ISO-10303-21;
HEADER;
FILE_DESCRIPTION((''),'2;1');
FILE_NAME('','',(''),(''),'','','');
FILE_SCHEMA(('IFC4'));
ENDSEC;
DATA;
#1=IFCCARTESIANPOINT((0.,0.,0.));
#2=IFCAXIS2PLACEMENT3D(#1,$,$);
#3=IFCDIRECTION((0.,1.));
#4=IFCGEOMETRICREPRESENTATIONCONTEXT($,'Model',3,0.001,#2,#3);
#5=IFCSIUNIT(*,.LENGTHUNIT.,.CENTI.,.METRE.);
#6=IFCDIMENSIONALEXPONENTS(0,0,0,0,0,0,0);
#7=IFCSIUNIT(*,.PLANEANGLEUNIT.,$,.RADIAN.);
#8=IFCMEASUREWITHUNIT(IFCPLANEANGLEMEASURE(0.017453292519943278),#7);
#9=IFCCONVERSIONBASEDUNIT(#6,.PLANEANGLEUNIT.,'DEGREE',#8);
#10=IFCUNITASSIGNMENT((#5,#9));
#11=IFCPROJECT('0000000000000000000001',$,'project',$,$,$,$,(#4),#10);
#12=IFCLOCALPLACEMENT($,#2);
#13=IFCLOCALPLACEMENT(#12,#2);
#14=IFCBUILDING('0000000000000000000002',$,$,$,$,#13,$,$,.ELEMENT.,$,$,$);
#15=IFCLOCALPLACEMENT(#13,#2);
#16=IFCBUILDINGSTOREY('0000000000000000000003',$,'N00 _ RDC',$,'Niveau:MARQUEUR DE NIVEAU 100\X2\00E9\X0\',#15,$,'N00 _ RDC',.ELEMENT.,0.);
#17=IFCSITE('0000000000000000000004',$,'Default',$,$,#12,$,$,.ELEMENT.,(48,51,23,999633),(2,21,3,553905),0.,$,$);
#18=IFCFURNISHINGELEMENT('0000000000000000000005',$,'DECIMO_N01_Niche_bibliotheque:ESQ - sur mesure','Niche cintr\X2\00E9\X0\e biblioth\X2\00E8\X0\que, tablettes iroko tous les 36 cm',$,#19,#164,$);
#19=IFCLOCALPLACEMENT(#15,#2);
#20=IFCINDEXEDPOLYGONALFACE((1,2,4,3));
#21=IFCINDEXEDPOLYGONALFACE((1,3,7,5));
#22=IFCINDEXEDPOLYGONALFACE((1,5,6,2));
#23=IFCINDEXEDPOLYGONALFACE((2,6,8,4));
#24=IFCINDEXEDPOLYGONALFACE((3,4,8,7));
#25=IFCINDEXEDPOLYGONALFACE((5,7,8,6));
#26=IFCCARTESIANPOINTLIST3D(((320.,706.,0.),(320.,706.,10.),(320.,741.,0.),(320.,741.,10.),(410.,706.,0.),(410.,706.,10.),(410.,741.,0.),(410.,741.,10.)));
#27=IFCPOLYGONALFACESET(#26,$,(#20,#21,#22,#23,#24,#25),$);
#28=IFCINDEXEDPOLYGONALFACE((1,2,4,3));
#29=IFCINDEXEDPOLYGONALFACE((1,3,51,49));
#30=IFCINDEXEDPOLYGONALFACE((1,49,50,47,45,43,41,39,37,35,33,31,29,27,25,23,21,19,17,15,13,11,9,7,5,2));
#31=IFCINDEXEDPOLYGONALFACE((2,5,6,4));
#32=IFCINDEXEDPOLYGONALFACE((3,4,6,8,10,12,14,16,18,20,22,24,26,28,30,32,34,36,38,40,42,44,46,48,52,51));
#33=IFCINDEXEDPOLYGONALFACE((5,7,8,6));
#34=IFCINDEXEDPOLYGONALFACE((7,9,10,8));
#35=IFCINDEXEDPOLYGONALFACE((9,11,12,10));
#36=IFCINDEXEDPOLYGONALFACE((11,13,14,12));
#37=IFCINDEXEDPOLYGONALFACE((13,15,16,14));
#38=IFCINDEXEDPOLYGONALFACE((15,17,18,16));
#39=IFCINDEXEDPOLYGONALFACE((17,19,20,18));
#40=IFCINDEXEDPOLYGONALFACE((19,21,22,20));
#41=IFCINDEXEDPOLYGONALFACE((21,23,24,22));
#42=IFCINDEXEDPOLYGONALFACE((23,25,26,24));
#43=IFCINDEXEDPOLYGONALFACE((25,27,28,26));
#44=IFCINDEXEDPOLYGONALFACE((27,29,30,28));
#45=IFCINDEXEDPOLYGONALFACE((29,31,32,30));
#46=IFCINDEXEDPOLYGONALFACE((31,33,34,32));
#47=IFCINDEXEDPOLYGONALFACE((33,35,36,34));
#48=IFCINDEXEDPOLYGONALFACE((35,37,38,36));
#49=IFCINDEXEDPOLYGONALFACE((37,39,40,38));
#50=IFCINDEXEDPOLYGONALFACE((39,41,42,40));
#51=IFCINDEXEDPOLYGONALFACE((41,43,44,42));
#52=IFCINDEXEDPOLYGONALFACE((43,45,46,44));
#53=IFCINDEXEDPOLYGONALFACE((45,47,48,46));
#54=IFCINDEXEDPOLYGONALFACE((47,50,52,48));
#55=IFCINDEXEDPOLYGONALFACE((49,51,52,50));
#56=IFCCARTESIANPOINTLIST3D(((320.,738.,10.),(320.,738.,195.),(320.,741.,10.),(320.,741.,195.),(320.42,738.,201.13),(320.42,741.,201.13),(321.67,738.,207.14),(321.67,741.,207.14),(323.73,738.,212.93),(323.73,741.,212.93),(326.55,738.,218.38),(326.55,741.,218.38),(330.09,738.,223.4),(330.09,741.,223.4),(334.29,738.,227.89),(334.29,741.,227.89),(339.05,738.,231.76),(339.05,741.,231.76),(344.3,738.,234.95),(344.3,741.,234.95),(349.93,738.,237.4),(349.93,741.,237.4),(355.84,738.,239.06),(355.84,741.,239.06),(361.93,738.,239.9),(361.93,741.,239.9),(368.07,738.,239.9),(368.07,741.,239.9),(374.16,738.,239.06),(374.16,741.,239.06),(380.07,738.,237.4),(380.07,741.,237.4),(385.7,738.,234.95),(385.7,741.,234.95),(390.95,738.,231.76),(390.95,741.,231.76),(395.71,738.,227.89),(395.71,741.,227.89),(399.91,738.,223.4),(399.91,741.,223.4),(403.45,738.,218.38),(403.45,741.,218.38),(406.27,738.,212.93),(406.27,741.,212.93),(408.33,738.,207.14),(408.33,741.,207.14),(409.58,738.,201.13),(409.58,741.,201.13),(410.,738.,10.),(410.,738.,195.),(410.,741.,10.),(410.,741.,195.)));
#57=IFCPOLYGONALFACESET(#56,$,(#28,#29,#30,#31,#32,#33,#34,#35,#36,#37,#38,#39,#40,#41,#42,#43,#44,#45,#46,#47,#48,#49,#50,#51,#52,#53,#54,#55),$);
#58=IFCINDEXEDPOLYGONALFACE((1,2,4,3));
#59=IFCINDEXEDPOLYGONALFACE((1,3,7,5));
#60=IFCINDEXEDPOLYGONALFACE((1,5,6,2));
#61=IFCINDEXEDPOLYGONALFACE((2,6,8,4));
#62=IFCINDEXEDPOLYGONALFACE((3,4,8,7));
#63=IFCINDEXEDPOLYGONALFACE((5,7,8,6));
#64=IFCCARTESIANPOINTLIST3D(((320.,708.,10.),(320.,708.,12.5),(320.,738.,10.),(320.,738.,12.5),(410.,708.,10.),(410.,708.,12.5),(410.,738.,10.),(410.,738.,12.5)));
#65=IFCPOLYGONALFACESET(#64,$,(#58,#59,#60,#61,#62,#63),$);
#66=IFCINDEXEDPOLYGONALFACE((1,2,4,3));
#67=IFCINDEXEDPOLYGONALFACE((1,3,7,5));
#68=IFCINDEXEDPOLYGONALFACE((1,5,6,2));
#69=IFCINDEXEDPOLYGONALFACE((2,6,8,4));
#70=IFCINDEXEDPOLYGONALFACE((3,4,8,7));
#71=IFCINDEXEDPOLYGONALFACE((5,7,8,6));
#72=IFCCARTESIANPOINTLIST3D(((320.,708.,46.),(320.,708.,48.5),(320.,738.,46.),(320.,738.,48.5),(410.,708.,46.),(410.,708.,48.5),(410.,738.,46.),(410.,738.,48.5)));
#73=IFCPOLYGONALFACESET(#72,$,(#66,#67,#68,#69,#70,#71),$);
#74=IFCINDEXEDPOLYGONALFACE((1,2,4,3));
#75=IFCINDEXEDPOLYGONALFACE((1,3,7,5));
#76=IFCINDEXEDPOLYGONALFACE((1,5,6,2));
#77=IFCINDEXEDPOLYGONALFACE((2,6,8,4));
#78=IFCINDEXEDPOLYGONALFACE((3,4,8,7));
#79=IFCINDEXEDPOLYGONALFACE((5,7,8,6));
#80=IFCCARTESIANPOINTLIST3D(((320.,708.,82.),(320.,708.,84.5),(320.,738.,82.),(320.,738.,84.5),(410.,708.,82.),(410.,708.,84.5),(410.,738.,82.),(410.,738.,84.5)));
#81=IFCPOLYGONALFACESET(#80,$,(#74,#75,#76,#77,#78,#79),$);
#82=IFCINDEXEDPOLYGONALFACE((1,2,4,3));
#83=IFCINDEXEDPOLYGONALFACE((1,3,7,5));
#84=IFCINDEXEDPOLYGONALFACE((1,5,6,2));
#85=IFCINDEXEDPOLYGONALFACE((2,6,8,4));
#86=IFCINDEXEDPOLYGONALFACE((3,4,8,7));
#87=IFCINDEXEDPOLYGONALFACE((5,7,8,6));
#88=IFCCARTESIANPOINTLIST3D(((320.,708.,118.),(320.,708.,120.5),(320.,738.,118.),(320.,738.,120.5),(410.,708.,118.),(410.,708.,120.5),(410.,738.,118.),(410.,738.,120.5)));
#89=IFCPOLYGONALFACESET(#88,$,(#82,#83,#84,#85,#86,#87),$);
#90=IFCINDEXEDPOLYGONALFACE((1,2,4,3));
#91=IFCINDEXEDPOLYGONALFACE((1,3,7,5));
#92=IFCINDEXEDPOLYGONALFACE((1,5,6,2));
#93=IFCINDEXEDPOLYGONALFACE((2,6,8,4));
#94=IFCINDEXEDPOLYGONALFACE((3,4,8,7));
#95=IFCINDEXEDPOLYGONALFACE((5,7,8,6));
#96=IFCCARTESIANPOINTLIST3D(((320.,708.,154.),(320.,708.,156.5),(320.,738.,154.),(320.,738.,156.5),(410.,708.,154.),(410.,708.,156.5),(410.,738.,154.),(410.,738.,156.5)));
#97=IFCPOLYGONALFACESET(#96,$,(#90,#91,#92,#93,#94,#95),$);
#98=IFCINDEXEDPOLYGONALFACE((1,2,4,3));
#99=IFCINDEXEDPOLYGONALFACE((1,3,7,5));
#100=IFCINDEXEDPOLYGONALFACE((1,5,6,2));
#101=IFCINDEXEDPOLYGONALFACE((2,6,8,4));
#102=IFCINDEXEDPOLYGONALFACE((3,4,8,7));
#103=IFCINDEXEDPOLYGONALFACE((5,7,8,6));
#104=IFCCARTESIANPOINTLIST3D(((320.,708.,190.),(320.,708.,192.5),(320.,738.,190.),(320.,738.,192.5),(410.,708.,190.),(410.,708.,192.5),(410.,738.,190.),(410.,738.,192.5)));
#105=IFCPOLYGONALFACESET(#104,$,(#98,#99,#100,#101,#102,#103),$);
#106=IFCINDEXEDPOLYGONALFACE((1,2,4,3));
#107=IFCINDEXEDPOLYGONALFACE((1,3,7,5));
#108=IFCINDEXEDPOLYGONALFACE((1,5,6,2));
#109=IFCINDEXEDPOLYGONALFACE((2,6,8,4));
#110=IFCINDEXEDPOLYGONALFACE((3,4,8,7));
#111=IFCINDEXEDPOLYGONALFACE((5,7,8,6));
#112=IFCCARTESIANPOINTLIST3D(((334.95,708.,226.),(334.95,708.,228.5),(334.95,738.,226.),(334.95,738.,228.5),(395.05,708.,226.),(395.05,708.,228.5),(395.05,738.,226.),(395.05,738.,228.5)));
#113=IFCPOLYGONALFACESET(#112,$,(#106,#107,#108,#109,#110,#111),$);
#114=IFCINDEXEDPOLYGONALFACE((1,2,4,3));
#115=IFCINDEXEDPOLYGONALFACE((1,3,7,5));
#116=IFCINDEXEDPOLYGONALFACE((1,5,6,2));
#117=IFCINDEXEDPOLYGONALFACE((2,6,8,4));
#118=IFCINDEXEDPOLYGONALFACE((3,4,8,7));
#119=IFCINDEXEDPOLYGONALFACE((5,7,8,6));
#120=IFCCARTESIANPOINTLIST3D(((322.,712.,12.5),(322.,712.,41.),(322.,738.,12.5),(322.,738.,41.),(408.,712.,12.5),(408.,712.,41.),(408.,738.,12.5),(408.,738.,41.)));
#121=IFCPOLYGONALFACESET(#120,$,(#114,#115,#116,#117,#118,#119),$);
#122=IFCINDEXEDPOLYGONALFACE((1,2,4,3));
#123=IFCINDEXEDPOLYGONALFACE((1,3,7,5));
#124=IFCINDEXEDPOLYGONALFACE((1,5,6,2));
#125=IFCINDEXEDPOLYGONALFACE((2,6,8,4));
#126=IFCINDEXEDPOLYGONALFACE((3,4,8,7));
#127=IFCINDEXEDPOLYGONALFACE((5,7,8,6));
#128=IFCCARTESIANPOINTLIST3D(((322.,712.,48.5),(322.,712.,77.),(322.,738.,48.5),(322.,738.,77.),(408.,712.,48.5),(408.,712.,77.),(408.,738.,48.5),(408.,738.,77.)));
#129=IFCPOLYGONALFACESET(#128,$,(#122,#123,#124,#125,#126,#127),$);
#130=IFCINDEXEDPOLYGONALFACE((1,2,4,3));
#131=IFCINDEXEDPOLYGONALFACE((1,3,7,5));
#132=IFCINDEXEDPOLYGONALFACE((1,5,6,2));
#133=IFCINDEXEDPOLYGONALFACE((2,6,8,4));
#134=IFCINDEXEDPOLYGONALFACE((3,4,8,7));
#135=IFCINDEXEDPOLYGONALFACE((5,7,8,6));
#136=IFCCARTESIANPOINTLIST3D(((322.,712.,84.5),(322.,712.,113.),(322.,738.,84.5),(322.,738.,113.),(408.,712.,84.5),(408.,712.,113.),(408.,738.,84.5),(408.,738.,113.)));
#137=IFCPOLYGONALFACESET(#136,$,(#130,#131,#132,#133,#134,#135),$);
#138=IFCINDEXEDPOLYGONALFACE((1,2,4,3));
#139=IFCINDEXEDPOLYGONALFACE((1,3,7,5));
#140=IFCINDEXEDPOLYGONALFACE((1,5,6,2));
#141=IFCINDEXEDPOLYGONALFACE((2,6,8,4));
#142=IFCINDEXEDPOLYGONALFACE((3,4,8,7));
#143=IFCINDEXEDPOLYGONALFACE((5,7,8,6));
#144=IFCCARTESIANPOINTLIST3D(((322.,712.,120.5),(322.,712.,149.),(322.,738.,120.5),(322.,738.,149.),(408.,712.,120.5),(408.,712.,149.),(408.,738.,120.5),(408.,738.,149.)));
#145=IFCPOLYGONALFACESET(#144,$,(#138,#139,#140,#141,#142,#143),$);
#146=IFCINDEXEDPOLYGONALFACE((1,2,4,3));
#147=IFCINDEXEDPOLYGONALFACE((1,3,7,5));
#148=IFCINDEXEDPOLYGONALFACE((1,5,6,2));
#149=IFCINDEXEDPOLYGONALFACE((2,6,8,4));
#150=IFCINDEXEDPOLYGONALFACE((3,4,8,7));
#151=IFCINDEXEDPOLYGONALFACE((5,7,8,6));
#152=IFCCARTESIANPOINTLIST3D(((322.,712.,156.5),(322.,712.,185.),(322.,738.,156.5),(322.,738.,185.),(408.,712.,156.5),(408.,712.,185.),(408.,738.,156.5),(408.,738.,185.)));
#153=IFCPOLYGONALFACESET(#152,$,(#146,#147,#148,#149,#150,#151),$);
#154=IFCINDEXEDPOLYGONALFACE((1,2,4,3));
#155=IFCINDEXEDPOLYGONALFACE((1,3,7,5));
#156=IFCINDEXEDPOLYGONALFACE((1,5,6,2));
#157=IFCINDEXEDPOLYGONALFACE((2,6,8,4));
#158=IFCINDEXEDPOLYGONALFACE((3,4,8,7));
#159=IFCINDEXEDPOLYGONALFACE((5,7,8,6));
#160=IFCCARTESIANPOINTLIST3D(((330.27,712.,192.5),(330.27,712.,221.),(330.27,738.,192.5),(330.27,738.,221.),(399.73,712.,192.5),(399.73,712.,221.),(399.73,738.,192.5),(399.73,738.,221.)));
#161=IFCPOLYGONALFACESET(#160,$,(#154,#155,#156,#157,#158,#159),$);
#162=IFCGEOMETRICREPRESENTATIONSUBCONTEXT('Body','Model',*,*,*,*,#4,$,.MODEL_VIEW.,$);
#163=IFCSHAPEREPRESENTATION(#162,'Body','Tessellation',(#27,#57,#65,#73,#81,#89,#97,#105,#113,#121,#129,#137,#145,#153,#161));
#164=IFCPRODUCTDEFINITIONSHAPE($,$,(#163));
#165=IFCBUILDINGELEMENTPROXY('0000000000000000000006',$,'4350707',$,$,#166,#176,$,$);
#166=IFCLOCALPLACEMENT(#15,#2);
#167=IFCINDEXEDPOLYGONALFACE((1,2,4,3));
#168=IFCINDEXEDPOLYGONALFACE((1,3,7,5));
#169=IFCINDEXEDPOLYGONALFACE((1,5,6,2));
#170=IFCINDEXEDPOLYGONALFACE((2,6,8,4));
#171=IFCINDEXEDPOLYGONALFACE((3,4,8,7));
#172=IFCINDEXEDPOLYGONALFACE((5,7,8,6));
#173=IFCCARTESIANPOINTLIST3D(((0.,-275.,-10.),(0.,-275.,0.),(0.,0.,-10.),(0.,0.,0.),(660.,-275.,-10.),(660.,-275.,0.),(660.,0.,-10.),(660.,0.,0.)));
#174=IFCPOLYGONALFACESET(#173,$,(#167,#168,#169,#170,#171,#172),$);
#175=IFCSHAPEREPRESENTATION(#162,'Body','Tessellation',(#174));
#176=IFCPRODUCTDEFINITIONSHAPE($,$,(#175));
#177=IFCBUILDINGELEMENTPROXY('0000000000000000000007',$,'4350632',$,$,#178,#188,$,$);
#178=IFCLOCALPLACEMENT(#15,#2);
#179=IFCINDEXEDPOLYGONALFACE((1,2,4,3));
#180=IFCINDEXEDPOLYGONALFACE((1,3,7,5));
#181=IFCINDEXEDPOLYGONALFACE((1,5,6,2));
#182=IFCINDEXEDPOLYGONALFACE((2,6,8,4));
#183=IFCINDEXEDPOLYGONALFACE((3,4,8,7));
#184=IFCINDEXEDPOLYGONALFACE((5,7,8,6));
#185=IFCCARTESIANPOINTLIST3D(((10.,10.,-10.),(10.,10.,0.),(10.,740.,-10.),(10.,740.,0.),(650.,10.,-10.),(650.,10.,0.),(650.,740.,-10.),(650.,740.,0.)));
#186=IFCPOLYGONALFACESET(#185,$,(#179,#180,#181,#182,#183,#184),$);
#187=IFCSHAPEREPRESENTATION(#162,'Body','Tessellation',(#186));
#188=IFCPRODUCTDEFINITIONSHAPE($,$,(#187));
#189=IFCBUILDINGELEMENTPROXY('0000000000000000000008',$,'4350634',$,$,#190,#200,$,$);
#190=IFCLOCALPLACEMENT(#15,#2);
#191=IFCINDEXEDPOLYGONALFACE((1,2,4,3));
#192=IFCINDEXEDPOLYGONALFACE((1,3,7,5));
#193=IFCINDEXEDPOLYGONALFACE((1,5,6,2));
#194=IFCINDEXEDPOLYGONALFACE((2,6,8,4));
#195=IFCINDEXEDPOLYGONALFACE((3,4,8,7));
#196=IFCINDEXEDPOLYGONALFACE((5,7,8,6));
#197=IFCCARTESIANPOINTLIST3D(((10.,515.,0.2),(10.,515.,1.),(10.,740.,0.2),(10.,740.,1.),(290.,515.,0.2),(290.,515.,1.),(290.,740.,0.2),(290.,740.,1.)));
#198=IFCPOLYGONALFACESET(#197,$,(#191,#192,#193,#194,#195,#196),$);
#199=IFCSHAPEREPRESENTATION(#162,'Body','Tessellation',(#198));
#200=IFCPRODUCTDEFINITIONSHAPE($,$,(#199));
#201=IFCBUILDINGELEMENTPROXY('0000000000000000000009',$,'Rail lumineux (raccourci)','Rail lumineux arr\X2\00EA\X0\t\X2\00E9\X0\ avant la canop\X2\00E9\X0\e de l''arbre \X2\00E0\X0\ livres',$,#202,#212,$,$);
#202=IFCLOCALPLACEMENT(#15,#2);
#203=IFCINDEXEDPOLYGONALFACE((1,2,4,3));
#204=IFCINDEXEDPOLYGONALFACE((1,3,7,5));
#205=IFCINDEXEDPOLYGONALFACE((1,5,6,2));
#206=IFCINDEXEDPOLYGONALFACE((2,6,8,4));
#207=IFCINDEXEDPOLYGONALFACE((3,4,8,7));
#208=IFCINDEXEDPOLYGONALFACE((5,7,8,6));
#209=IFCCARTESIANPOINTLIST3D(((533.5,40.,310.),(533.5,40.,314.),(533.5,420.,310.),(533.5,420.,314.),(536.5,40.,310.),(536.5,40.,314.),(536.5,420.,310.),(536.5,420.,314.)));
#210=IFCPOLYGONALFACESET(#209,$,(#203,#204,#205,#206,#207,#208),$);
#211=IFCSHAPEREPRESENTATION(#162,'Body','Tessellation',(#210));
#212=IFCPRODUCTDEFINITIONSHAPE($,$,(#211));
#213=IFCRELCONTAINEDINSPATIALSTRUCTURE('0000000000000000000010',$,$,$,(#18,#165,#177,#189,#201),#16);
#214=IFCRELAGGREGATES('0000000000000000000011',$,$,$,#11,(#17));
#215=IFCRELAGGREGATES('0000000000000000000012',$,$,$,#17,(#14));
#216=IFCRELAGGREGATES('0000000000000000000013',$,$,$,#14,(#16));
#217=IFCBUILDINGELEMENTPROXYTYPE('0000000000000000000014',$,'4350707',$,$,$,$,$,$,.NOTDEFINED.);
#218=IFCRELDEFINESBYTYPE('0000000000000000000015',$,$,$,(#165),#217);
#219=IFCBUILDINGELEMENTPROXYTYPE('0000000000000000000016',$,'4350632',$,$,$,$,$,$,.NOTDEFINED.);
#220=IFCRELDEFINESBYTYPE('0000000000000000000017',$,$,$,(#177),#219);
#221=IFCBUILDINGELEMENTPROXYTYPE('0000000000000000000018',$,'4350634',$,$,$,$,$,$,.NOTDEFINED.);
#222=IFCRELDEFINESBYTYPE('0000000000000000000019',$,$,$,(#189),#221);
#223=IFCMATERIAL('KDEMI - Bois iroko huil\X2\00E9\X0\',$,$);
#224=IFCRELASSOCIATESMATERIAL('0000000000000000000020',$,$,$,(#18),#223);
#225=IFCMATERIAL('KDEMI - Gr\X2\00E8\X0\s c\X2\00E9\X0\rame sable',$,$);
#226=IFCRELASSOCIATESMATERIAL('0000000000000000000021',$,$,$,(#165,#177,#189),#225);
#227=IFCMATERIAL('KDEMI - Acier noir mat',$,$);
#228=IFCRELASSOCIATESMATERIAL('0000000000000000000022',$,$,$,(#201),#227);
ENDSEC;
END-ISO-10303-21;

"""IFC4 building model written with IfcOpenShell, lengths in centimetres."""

from ifc_helpers import new_model, entity, si_unit, converted_unit, direction, frame, frame_2d, origin, origin_with_axes, origin_2d_with_axis, place, context, subcontext, project, spatial, polyline, rectangle, outline, extrude, material, type_object, element, save


model = new_model("IFC4")

# Units and contexts
model_context = context("Model", 3, precision=0.001, world=origin(), true_north=direction((0.0, 1.0)))
body_context = subcontext(model_context, "Body", "Model", "MODEL_VIEW")
ifc_project = project(units=[si_unit("LENGTHUNIT", "METRE", prefix="CENTI"), converted_unit("PLANEANGLEUNIT", "DEGREE", entity("IfcPlaneAngleMeasure", 0.017453292519943278), si_unit("PLANEANGLEUNIT", "RADIAN"), dimensions=[0, 0, 0, 0, 0, 0, 0])], contexts=[model_context])

# Site, building, storey
site_placement = place(None, origin())
site = spatial("IfcSite", under=ifc_project, at=site_placement, Name="Default", CompositionType="ELEMENT", RefLatitude=(48, 51, 23, 999633), RefLongitude=(2, 21, 3, 553905), RefElevation=0.0)
building_placement = place(site_placement, origin())
building = spatial("IfcBuilding", under=site, at=building_placement, CompositionType="ELEMENT")
storey_placement = place(building_placement, origin())
storey = spatial("IfcBuildingStorey", under=building, at=storey_placement, Name="N00 _ RDC", ObjectType="Niveau:MARQUEUR DE NIVEAU 100é", LongName="N00 _ RDC", CompositionType="ELEMENT", Elevation=0.0)

# Furnishing element
ifc_material_1 = material(Name="KDEMI - Bois iroko huilé")
furnishing_1_placement = place(storey_placement, origin_with_axes())
element("IfcFurnishingElement", 1, at=furnishing_1_placement, inside=storey, material=ifc_material_1, Name="DECIMO_N01_Niche_bibliotheque:ESQ - sur mesure", Description="Niche cintrée bibliothèque, tablettes iroko tous les 36 cm", context=body_context, shape_type="SweptSolid", body=[
    extrude(rectangle(XDim=90.0, YDim=35.0, at=frame_2d((365.0, 723.5))), origin(), (0.0, 0.0, 1.0), 10.0),
    extrude(outline(polyline([(320.0, 10.0), (410.0, 10.0), (410.0, 195.0), (409.58, 201.13), (408.33, 207.14), (406.27, 212.93), (403.45, 218.38), (399.91, 223.4), (395.71, 227.89), (390.95, 231.76), (385.7, 234.95), (380.07, 237.4), (374.16, 239.06), (368.07, 239.9), (361.93, 239.9), (355.84, 239.06), (349.93, 237.4), (344.3, 234.95), (339.05, 231.76), (334.29, 227.89), (330.09, 223.4), (326.55, 218.38), (323.73, 212.93), (321.67, 207.14), (320.42, 201.13), (320.0, 195.0), (320.0, 10.0)])), frame((0.0, 741.0, 0.0), z_axis=(0.0, -1.0, 0.0), x_axis=(1.0, 0.0, 0.0)), (0.0, 0.0, 1.0), 3.0),
    extrude(rectangle(XDim=90.0, YDim=30.0, at=frame_2d((365.0, 723.0))), frame((0.0, 0.0, 10.0)), (0.0, 0.0, 1.0), 2.5),
    extrude(rectangle(XDim=90.0, YDim=30.0, at=frame_2d((365.0, 723.0))), frame((0.0, 0.0, 46.0)), (0.0, 0.0, 1.0), 2.5),
    extrude(rectangle(XDim=90.0, YDim=30.0, at=frame_2d((365.0, 723.0))), frame((0.0, 0.0, 82.0)), (0.0, 0.0, 1.0), 2.5),
    extrude(rectangle(XDim=90.0, YDim=30.0, at=frame_2d((365.0, 723.0))), frame((0.0, 0.0, 118.0)), (0.0, 0.0, 1.0), 2.5),
    extrude(rectangle(XDim=90.0, YDim=30.0, at=frame_2d((365.0, 723.0))), frame((0.0, 0.0, 154.0)), (0.0, 0.0, 1.0), 2.5),
    extrude(rectangle(XDim=90.0, YDim=30.0, at=frame_2d((365.0, 723.0))), frame((0.0, 0.0, 190.0)), (0.0, 0.0, 1.0), 2.5),
    extrude(rectangle(XDim=60.09, YDim=30.0, at=frame_2d((365.0, 723.0))), frame((0.0, 0.0, 226.0)), (0.0, 0.0, 1.0), 2.5),
    extrude(rectangle(XDim=86.0, YDim=26.0, at=frame_2d((365.0, 725.0))), frame((0.0, 0.0, 12.5)), (0.0, 0.0, 1.0), 28.5),
    extrude(rectangle(XDim=86.0, YDim=26.0, at=frame_2d((365.0, 725.0))), frame((0.0, 0.0, 48.5)), (0.0, 0.0, 1.0), 28.5),
    extrude(rectangle(XDim=86.0, YDim=26.0, at=frame_2d((365.0, 725.0))), frame((0.0, 0.0, 84.5)), (0.0, 0.0, 1.0), 28.5),
    extrude(rectangle(XDim=86.0, YDim=26.0, at=frame_2d((365.0, 725.0))), frame((0.0, 0.0, 120.5)), (0.0, 0.0, 1.0), 28.5),
    extrude(rectangle(XDim=86.0, YDim=26.0, at=frame_2d((365.0, 725.0))), frame((0.0, 0.0, 156.5)), (0.0, 0.0, 1.0), 28.5),
    extrude(rectangle(XDim=69.46, YDim=26.0, at=frame_2d((365.0, 725.0))), frame((0.0, 0.0, 192.5)), (0.0, 0.0, 1.0), 28.5),
])

# Building element proxies
ifc_material_2 = material(Name="KDEMI - Grès cérame sable")
building_element_proxy_type_1 = type_object("IfcBuildingElementProxyType", Name="4350707", PredefinedType="NOTDEFINED")
proxy_1_placement = place(storey_placement, origin())
element("IfcBuildingElementProxy", 2, at=proxy_1_placement, inside=storey, type_object=building_element_proxy_type_1, material=ifc_material_2, Name="4350707", context=body_context, shape_type="SweptSolid", body=[
    extrude(rectangle(XDim=660.0, YDim=275.0, at=origin_2d_with_axis()), frame((330.0, -137.5, -10.0)), (0.0, 0.0, 1.0), 10.0),
])
building_element_proxy_type_2 = type_object("IfcBuildingElementProxyType", Name="4350632", PredefinedType="NOTDEFINED")
proxy_2_placement = place(storey_placement, origin())
element("IfcBuildingElementProxy", 3, at=proxy_2_placement, inside=storey, type_object=building_element_proxy_type_2, material=ifc_material_2, Name="4350632", context=body_context, shape_type="SweptSolid", body=[
    extrude(rectangle(XDim=640.0, YDim=730.0, at=origin_2d_with_axis()), frame((330.0, 375.0, -10.0)), (0.0, 0.0, 1.0), 10.0),
])
building_element_proxy_type_3 = type_object("IfcBuildingElementProxyType", Name="4350634", PredefinedType="NOTDEFINED")
proxy_3_placement = place(storey_placement, origin())
element("IfcBuildingElementProxy", 4, at=proxy_3_placement, inside=storey, type_object=building_element_proxy_type_3, material=ifc_material_2, Name="4350634", context=body_context, shape_type="SweptSolid", body=[
    extrude(rectangle(XDim=280.0, YDim=225.0, at=frame_2d((0.0, 0.0), x_axis=(1.0, 0.0))), frame((150.0, 627.5, 0.2)), (0.0, 0.0, 1.0), 0.8),
])
ifc_material_3 = material(Name="KDEMI - Acier noir mat")
proxy_4_placement = place(storey_placement, origin_with_axes())
element("IfcBuildingElementProxy", 5, at=proxy_4_placement, inside=storey, material=ifc_material_3, Name="Rail lumineux (raccourci)", Description="Rail lumineux arrêté avant la canopée de l'arbre à livres", context=body_context, shape_type="SweptSolid", body=[
    extrude(rectangle(XDim=3.0, YDim=380.0, at=frame_2d((535.0, 230.0))), frame((0.0, 0.0, 310.0)), (0.0, 0.0, 1.0), 4.0),
])

save(model, "model.ifc")
